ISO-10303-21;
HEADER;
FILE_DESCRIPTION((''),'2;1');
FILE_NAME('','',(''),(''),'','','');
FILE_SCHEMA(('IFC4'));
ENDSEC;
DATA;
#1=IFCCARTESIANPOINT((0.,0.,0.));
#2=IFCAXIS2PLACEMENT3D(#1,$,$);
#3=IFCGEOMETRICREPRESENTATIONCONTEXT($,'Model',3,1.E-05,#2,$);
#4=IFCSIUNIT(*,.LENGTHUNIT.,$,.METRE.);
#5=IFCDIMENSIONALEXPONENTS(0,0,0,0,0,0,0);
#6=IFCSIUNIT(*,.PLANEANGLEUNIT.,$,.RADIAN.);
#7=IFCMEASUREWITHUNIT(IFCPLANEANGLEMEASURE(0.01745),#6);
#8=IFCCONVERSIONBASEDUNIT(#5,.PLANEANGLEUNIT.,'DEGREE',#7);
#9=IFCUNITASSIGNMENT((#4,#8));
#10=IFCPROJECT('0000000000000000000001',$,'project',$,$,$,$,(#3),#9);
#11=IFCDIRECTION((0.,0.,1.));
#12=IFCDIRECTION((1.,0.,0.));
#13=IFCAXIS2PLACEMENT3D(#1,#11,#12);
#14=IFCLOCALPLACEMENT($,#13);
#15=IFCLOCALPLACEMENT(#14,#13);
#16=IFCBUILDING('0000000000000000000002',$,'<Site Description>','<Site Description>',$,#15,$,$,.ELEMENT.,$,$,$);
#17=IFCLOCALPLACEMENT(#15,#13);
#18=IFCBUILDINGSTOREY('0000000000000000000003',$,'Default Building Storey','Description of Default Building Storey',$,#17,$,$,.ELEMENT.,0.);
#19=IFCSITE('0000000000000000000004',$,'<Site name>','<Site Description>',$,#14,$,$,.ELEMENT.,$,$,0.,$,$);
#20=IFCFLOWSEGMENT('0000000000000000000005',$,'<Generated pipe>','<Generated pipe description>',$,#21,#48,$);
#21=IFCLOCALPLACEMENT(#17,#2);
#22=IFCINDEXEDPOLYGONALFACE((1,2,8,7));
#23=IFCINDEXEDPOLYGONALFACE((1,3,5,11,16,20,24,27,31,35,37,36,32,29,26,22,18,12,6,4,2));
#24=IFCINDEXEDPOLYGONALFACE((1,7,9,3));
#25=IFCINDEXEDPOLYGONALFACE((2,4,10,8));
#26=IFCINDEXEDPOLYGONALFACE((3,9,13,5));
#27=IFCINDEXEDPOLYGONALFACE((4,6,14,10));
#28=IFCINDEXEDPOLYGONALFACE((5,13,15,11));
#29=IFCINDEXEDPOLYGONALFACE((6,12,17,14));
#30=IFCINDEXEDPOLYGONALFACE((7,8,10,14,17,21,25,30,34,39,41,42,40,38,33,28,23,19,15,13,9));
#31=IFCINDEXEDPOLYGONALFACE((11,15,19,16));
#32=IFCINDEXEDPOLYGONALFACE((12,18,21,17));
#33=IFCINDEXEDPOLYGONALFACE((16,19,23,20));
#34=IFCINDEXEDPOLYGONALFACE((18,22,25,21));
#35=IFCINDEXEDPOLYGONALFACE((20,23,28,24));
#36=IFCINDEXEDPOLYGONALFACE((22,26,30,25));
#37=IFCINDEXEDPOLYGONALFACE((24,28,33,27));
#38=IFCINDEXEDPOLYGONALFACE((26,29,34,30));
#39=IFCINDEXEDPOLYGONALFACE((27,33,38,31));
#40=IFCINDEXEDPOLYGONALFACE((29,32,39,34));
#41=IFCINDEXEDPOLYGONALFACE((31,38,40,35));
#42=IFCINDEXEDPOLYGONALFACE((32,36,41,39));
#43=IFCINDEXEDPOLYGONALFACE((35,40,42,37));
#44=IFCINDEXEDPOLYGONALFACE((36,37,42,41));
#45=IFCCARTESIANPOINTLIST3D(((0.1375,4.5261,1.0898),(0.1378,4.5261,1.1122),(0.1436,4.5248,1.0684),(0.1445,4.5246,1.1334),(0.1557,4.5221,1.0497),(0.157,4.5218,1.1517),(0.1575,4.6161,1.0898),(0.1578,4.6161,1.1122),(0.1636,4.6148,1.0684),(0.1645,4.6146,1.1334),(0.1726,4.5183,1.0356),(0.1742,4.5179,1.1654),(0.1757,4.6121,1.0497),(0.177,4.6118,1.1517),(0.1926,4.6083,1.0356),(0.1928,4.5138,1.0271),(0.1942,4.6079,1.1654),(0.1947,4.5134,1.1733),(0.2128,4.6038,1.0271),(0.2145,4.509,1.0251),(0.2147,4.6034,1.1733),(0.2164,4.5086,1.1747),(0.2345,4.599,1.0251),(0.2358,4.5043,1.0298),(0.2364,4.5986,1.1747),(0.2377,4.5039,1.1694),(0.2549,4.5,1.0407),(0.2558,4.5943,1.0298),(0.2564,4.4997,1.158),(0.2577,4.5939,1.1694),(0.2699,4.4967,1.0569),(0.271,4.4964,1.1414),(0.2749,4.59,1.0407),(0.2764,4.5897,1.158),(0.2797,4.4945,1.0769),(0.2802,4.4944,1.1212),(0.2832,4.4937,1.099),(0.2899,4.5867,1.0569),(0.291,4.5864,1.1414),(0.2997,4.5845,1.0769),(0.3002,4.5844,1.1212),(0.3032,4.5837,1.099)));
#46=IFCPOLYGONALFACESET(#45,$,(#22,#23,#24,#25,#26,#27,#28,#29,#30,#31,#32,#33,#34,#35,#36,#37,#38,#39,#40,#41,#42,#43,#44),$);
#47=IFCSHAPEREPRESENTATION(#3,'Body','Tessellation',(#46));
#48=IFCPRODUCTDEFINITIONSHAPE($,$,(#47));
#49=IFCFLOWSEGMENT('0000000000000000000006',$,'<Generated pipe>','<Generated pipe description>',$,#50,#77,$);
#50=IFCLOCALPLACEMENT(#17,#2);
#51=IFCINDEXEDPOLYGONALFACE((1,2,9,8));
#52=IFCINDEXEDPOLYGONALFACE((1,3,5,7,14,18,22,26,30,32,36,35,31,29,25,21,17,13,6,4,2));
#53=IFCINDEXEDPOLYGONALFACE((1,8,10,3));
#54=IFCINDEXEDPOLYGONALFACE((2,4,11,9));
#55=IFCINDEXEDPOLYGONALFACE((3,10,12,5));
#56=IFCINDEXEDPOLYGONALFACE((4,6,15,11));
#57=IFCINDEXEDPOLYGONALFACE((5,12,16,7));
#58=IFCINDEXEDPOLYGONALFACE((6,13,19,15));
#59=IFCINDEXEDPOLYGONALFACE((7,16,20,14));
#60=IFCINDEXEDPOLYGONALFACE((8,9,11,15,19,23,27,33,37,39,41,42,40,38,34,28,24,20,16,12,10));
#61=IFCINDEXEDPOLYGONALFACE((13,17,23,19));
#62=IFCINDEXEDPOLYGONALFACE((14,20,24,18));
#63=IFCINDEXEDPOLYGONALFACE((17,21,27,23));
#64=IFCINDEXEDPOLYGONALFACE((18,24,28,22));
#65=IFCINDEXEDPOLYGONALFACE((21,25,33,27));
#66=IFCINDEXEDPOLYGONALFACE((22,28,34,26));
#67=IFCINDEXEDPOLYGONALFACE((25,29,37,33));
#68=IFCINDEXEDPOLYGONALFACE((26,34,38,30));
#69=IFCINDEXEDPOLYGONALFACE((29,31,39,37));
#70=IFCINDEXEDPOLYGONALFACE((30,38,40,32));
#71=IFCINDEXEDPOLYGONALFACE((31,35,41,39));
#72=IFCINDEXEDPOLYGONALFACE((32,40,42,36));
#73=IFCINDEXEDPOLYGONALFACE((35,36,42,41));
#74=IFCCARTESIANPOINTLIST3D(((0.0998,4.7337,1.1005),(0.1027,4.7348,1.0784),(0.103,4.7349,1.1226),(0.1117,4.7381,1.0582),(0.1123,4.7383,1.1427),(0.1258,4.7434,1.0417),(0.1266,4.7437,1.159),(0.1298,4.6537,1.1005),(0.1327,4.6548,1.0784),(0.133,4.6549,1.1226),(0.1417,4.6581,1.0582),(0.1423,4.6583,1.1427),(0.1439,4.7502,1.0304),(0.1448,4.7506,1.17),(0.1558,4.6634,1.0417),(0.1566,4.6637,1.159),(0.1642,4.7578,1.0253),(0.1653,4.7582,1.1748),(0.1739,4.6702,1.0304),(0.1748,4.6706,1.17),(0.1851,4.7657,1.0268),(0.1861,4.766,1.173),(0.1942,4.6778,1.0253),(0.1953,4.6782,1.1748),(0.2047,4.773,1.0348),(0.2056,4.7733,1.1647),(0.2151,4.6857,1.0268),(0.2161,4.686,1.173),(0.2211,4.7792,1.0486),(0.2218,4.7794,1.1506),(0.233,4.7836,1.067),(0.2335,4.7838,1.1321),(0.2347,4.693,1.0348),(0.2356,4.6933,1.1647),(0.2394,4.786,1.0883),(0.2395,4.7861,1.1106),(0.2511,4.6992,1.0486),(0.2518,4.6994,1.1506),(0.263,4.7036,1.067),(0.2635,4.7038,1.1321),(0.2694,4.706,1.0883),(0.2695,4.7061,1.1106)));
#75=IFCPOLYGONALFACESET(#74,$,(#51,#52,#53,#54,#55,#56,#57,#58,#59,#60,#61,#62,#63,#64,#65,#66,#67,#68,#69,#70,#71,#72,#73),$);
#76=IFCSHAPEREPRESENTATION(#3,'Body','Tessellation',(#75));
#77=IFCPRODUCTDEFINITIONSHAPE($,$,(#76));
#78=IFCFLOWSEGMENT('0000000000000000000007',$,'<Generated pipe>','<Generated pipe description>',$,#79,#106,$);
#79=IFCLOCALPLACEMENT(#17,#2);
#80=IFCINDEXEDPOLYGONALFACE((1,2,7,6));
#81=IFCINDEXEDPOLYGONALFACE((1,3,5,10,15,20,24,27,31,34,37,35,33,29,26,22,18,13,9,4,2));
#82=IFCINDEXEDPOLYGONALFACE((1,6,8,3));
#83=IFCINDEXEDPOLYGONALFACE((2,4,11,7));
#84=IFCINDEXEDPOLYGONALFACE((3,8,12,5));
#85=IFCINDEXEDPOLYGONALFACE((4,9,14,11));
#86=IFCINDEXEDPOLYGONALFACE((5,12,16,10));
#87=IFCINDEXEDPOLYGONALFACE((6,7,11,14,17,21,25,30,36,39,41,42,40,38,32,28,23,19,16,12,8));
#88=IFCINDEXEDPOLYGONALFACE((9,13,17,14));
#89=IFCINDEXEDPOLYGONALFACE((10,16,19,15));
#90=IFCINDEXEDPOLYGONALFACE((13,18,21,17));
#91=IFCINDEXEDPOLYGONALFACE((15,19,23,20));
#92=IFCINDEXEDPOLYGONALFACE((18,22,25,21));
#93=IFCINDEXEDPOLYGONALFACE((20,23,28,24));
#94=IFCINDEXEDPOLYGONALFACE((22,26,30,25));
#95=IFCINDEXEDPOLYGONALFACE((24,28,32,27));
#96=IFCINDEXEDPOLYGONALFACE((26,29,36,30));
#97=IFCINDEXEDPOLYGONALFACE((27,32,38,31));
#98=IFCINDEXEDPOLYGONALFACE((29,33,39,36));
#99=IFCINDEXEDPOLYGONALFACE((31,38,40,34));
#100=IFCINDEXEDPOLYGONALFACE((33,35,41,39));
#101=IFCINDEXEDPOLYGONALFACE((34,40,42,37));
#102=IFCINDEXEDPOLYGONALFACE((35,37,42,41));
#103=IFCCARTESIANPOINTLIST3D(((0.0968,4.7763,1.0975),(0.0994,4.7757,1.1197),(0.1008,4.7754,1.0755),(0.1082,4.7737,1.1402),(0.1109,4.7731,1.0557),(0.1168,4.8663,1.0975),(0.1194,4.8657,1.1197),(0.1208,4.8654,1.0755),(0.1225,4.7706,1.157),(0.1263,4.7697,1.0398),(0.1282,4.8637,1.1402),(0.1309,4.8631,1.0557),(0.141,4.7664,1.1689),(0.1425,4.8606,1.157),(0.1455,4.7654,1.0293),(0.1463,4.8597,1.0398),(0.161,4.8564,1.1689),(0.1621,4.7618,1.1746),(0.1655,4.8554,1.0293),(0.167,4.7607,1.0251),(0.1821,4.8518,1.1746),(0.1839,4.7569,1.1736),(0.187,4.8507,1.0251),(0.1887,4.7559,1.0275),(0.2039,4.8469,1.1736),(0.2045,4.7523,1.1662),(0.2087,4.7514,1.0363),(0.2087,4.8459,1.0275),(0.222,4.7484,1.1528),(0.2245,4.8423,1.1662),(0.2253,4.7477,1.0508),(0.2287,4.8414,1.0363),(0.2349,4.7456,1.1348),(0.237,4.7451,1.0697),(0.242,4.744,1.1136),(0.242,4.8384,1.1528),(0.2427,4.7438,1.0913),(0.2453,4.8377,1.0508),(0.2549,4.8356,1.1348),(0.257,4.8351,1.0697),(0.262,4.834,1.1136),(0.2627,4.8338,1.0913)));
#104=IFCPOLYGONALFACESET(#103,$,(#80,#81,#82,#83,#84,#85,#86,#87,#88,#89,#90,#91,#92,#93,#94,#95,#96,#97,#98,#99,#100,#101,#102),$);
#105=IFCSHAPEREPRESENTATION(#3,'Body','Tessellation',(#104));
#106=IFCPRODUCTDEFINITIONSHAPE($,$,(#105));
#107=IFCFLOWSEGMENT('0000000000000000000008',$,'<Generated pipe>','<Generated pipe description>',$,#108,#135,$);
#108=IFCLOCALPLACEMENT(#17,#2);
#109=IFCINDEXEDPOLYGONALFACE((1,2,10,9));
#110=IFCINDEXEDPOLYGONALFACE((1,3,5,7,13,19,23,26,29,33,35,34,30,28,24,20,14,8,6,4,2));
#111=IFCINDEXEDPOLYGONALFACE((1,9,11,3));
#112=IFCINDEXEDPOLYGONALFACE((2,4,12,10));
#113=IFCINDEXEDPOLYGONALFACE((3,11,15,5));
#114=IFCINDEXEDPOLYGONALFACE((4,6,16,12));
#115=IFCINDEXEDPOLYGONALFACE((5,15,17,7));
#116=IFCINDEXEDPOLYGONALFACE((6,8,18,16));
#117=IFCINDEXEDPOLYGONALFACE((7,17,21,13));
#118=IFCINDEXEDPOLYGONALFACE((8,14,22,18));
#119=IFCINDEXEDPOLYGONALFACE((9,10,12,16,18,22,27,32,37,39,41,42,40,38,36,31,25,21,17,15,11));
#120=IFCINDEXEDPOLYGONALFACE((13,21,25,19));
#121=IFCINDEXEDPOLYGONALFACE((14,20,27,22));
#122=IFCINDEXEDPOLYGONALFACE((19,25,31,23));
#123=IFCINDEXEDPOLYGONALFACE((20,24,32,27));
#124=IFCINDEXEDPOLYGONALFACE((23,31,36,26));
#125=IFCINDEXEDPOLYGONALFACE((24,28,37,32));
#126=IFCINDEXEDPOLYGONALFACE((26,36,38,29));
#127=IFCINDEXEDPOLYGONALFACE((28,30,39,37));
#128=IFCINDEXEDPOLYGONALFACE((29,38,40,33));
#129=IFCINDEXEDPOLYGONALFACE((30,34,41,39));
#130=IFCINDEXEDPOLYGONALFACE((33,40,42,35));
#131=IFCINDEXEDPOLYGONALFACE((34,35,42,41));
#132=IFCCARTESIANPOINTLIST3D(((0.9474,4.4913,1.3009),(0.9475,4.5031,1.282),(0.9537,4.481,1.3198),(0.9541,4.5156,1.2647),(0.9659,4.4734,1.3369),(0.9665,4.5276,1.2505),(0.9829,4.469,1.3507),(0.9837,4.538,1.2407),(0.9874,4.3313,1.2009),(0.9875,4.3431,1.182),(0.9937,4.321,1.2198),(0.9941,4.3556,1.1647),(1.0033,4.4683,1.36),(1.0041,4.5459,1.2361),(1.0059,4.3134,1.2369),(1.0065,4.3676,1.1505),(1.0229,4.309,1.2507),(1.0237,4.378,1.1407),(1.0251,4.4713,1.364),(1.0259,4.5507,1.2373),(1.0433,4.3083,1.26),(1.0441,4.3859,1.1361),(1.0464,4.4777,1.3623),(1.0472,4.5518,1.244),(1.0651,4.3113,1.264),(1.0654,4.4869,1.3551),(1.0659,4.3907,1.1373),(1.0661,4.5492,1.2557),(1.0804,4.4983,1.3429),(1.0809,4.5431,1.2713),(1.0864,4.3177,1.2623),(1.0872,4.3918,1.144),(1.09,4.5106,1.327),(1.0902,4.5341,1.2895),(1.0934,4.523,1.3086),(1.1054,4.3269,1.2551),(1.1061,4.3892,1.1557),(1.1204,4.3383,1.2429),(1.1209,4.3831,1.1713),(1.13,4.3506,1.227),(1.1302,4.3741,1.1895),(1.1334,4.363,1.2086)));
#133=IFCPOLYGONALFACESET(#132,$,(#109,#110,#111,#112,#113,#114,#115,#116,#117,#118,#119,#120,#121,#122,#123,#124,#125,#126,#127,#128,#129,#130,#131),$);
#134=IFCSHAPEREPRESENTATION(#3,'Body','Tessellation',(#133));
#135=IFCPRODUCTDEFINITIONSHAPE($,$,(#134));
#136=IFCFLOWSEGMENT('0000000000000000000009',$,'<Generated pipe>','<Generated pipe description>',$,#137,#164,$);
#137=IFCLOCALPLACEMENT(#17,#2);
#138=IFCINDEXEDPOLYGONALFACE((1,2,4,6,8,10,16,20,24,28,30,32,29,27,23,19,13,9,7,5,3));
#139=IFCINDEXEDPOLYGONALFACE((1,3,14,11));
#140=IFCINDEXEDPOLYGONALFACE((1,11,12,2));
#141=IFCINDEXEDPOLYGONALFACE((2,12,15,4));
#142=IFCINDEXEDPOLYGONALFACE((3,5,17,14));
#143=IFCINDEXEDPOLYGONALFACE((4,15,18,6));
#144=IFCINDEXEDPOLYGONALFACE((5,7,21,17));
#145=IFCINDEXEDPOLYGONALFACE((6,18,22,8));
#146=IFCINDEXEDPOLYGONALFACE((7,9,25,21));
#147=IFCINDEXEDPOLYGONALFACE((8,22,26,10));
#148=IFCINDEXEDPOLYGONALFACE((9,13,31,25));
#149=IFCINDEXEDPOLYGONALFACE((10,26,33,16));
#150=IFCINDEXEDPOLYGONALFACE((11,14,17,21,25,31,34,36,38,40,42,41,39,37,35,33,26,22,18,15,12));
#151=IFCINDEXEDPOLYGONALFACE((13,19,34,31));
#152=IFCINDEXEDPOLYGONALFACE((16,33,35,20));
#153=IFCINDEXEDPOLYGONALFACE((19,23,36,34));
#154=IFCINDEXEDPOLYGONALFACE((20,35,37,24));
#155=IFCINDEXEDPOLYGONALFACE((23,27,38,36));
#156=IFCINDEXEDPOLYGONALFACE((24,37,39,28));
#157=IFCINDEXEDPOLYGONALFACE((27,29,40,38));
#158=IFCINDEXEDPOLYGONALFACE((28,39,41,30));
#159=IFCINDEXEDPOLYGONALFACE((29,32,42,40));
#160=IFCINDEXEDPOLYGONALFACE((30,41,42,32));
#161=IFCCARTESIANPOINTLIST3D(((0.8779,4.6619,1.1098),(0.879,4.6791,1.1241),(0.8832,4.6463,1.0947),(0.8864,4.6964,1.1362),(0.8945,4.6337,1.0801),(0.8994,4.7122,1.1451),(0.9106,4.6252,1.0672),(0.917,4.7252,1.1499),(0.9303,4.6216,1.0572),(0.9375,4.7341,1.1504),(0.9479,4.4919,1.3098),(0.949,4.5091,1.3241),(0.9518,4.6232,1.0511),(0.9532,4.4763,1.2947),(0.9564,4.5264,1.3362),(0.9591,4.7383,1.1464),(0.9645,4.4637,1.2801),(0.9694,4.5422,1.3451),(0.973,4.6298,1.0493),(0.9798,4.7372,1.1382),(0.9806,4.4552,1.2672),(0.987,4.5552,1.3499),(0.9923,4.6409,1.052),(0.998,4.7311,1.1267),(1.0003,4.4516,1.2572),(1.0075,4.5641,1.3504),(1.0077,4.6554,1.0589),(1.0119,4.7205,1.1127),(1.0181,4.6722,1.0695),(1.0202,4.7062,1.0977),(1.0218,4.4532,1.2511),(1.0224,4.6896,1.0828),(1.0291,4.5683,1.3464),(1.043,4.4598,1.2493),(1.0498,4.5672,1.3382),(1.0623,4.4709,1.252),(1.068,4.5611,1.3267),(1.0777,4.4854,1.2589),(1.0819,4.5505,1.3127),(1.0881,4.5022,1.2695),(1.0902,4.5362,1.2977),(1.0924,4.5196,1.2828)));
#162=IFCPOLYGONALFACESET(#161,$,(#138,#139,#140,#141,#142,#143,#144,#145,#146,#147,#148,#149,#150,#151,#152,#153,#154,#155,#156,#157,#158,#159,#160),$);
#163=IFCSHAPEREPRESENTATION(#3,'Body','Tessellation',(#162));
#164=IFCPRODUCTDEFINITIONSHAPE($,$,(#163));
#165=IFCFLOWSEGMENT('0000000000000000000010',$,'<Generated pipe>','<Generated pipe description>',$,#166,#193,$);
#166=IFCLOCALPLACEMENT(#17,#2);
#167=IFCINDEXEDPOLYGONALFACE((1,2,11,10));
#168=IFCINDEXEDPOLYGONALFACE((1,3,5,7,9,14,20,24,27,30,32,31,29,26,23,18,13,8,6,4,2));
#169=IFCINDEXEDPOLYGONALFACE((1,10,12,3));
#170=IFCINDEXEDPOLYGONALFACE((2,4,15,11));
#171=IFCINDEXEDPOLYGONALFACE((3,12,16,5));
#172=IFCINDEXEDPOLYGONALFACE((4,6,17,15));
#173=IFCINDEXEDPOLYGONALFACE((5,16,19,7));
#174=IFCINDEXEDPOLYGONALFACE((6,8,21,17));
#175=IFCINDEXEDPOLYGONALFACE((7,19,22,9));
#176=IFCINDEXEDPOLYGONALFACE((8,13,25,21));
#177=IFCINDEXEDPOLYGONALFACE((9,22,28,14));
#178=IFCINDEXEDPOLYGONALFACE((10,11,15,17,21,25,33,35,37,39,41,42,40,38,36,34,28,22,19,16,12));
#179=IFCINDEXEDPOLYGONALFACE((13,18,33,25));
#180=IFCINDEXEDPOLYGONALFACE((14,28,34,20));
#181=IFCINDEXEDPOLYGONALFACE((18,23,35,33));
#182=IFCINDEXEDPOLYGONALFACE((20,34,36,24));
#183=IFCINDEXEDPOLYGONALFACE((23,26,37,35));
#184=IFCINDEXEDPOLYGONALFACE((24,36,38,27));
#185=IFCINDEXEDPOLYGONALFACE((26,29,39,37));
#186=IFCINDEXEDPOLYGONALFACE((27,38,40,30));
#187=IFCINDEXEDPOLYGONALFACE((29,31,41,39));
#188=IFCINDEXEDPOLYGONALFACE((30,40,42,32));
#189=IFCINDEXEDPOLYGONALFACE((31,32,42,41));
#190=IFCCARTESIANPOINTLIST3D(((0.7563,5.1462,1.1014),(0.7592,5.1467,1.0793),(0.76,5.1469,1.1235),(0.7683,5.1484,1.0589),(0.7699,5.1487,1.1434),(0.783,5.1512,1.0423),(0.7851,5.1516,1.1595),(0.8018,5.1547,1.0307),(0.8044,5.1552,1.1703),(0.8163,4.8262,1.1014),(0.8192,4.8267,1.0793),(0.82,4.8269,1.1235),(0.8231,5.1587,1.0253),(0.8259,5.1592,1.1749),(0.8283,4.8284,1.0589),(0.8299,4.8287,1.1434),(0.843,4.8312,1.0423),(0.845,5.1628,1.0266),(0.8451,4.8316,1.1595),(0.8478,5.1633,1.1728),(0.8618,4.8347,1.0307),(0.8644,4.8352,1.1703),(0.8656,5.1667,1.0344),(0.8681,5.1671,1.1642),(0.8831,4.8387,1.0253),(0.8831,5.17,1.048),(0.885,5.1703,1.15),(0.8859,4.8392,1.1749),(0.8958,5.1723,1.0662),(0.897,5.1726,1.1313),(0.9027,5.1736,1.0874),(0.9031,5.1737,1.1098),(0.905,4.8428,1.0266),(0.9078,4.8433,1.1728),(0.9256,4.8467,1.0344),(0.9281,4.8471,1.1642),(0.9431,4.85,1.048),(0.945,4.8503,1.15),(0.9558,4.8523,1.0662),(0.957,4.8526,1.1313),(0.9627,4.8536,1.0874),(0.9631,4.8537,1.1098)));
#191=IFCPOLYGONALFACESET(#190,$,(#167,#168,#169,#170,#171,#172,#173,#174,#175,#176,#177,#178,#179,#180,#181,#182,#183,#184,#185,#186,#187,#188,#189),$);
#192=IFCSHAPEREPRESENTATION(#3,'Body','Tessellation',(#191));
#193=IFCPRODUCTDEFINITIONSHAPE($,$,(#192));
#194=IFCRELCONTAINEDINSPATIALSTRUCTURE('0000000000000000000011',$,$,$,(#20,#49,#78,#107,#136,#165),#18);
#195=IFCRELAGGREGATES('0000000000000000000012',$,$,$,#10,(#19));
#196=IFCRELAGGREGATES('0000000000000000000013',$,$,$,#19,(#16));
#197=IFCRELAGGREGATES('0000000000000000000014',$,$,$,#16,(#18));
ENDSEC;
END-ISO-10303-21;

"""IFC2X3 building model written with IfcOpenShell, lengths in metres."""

from ifc_helpers import new_model, entity, si_unit, converted_unit, frame, origin, origin_with_axes, origin_2d_with_axis, place, context, project, spatial, circle, extrude, element, save


model = new_model("IFC2X3")

# Units and contexts
model_context = context("Model", 3, precision=1e-05, world=origin())
ifc_project = project(units=[si_unit("LENGTHUNIT", "METRE"), converted_unit("PLANEANGLEUNIT", "DEGREE", entity("IfcPlaneAngleMeasure", 0.01745), si_unit("PLANEANGLEUNIT", "RADIAN"), dimensions=[0, 0, 0, 0, 0, 0, 0])], contexts=[model_context])

# Site, building, storey
site_placement = place(None, origin_with_axes())
site = spatial("IfcSite", under=ifc_project, at=site_placement, Name="<Site name>", Description="<Site Description>", CompositionType="ELEMENT", RefElevation=0.0)
building_placement = place(site_placement, origin_with_axes())
building = spatial("IfcBuilding", under=site, at=building_placement, Name="<Site Description>", Description="<Site Description>", CompositionType="ELEMENT")
storey_placement = place(building_placement, origin_with_axes())
storey = spatial("IfcBuildingStorey", under=building, at=storey_placement, Name="Default Building Storey", Description="Description of Default Building Storey", CompositionType="ELEMENT", Elevation=0.0)

# Flow segments
flow_segment_1_placement = place(storey_placement, frame((0.21, 4.51, 1.1), z_axis=(0.21693, 0.976187, 0.0), x_axis=(-0.204575, 0.045461, 0.977795)))
element("IfcFlowSegment", 1, at=flow_segment_1_placement, inside=storey, Name="<Generated pipe>", Description="<Generated pipe description>", context=model_context, shape_type="SweptSolid", body=[
    extrude(circle(Radius=0.075, at=origin_2d_with_axis()), origin_with_axes(), (0.0, 0.0, 1.0), 0.0922),
])
flow_segment_2_placement = place(storey_placement, frame((0.2, 4.68, 1.1), z_axis=(-0.351123, 0.936329, 0.0), x_axis=(0.926855, 0.347571, 0.141894)))
element("IfcFlowSegment", 2, at=flow_segment_2_placement, inside=storey, Name="<Generated pipe>", Description="<Generated pipe description>", context=model_context, shape_type="SweptSolid", body=[
    extrude(circle(Radius=0.075, at=origin_2d_with_axis()), origin_with_axes(), (0.0, 0.0, 1.0), 0.0854),
])
flow_segment_3_placement = place(storey_placement, frame((0.17, 4.76, 1.1), z_axis=(0.21693, 0.976187, 0.0), x_axis=(0.185386, -0.041197, 0.981802)))
element("IfcFlowSegment", 3, at=flow_segment_3_placement, inside=storey, Name="<Generated pipe>", Description="<Generated pipe description>", context=model_context, shape_type="SweptSolid", body=[
    extrude(circle(Radius=0.075, at=origin_2d_with_axis()), origin_with_axes(), (0.0, 0.0, 1.0), 0.0922),
])
flow_segment_4_placement = place(storey_placement, frame((1.06, 4.35, 1.2), z_axis=(-0.20739, 0.829561, 0.518476), x_axis=(0.936478, 0.321591, -0.139955)))
element("IfcFlowSegment", 4, at=flow_segment_4_placement, inside=storey, Name="<Generated pipe>", Description="<Generated pipe description>", context=model_context, shape_type="SweptSolid", body=[
    extrude(circle(Radius=0.075, at=origin_2d_with_axis()), origin_with_axes(), (0.0, 0.0, 1.0), 0.1929),
])
flow_segment_5_placement = place(storey_placement, frame((1.02, 4.51, 1.3), z_axis=(-0.257674, 0.625779, -0.73621), x_axis=(0.639782, 0.681481, 0.355335)))
element("IfcFlowSegment", 5, at=flow_segment_5_placement, inside=storey, Name="<Generated pipe>", Description="<Generated pipe description>", context=model_context, shape_type="SweptSolid", body=[
    extrude(circle(Radius=0.075, at=origin_2d_with_axis()), origin_with_axes(), (0.0, 0.0, 1.0), 0.2717),
])
flow_segment_6_placement = place(storey_placement, frame((0.89, 4.84, 1.1), z_axis=(-0.184289, 0.982872, 0.0), x_axis=(0.893432, 0.167518, 0.416794)))
element("IfcFlowSegment", 6, at=flow_segment_6_placement, inside=storey, Name="<Generated pipe>", Description="<Generated pipe description>", context=model_context, shape_type="SweptSolid", body=[
    extrude(circle(Radius=0.075, at=origin_2d_with_axis()), origin_with_axes(), (0.0, 0.0, 1.0), 0.3256),
])

save(model, "model.ifc")
